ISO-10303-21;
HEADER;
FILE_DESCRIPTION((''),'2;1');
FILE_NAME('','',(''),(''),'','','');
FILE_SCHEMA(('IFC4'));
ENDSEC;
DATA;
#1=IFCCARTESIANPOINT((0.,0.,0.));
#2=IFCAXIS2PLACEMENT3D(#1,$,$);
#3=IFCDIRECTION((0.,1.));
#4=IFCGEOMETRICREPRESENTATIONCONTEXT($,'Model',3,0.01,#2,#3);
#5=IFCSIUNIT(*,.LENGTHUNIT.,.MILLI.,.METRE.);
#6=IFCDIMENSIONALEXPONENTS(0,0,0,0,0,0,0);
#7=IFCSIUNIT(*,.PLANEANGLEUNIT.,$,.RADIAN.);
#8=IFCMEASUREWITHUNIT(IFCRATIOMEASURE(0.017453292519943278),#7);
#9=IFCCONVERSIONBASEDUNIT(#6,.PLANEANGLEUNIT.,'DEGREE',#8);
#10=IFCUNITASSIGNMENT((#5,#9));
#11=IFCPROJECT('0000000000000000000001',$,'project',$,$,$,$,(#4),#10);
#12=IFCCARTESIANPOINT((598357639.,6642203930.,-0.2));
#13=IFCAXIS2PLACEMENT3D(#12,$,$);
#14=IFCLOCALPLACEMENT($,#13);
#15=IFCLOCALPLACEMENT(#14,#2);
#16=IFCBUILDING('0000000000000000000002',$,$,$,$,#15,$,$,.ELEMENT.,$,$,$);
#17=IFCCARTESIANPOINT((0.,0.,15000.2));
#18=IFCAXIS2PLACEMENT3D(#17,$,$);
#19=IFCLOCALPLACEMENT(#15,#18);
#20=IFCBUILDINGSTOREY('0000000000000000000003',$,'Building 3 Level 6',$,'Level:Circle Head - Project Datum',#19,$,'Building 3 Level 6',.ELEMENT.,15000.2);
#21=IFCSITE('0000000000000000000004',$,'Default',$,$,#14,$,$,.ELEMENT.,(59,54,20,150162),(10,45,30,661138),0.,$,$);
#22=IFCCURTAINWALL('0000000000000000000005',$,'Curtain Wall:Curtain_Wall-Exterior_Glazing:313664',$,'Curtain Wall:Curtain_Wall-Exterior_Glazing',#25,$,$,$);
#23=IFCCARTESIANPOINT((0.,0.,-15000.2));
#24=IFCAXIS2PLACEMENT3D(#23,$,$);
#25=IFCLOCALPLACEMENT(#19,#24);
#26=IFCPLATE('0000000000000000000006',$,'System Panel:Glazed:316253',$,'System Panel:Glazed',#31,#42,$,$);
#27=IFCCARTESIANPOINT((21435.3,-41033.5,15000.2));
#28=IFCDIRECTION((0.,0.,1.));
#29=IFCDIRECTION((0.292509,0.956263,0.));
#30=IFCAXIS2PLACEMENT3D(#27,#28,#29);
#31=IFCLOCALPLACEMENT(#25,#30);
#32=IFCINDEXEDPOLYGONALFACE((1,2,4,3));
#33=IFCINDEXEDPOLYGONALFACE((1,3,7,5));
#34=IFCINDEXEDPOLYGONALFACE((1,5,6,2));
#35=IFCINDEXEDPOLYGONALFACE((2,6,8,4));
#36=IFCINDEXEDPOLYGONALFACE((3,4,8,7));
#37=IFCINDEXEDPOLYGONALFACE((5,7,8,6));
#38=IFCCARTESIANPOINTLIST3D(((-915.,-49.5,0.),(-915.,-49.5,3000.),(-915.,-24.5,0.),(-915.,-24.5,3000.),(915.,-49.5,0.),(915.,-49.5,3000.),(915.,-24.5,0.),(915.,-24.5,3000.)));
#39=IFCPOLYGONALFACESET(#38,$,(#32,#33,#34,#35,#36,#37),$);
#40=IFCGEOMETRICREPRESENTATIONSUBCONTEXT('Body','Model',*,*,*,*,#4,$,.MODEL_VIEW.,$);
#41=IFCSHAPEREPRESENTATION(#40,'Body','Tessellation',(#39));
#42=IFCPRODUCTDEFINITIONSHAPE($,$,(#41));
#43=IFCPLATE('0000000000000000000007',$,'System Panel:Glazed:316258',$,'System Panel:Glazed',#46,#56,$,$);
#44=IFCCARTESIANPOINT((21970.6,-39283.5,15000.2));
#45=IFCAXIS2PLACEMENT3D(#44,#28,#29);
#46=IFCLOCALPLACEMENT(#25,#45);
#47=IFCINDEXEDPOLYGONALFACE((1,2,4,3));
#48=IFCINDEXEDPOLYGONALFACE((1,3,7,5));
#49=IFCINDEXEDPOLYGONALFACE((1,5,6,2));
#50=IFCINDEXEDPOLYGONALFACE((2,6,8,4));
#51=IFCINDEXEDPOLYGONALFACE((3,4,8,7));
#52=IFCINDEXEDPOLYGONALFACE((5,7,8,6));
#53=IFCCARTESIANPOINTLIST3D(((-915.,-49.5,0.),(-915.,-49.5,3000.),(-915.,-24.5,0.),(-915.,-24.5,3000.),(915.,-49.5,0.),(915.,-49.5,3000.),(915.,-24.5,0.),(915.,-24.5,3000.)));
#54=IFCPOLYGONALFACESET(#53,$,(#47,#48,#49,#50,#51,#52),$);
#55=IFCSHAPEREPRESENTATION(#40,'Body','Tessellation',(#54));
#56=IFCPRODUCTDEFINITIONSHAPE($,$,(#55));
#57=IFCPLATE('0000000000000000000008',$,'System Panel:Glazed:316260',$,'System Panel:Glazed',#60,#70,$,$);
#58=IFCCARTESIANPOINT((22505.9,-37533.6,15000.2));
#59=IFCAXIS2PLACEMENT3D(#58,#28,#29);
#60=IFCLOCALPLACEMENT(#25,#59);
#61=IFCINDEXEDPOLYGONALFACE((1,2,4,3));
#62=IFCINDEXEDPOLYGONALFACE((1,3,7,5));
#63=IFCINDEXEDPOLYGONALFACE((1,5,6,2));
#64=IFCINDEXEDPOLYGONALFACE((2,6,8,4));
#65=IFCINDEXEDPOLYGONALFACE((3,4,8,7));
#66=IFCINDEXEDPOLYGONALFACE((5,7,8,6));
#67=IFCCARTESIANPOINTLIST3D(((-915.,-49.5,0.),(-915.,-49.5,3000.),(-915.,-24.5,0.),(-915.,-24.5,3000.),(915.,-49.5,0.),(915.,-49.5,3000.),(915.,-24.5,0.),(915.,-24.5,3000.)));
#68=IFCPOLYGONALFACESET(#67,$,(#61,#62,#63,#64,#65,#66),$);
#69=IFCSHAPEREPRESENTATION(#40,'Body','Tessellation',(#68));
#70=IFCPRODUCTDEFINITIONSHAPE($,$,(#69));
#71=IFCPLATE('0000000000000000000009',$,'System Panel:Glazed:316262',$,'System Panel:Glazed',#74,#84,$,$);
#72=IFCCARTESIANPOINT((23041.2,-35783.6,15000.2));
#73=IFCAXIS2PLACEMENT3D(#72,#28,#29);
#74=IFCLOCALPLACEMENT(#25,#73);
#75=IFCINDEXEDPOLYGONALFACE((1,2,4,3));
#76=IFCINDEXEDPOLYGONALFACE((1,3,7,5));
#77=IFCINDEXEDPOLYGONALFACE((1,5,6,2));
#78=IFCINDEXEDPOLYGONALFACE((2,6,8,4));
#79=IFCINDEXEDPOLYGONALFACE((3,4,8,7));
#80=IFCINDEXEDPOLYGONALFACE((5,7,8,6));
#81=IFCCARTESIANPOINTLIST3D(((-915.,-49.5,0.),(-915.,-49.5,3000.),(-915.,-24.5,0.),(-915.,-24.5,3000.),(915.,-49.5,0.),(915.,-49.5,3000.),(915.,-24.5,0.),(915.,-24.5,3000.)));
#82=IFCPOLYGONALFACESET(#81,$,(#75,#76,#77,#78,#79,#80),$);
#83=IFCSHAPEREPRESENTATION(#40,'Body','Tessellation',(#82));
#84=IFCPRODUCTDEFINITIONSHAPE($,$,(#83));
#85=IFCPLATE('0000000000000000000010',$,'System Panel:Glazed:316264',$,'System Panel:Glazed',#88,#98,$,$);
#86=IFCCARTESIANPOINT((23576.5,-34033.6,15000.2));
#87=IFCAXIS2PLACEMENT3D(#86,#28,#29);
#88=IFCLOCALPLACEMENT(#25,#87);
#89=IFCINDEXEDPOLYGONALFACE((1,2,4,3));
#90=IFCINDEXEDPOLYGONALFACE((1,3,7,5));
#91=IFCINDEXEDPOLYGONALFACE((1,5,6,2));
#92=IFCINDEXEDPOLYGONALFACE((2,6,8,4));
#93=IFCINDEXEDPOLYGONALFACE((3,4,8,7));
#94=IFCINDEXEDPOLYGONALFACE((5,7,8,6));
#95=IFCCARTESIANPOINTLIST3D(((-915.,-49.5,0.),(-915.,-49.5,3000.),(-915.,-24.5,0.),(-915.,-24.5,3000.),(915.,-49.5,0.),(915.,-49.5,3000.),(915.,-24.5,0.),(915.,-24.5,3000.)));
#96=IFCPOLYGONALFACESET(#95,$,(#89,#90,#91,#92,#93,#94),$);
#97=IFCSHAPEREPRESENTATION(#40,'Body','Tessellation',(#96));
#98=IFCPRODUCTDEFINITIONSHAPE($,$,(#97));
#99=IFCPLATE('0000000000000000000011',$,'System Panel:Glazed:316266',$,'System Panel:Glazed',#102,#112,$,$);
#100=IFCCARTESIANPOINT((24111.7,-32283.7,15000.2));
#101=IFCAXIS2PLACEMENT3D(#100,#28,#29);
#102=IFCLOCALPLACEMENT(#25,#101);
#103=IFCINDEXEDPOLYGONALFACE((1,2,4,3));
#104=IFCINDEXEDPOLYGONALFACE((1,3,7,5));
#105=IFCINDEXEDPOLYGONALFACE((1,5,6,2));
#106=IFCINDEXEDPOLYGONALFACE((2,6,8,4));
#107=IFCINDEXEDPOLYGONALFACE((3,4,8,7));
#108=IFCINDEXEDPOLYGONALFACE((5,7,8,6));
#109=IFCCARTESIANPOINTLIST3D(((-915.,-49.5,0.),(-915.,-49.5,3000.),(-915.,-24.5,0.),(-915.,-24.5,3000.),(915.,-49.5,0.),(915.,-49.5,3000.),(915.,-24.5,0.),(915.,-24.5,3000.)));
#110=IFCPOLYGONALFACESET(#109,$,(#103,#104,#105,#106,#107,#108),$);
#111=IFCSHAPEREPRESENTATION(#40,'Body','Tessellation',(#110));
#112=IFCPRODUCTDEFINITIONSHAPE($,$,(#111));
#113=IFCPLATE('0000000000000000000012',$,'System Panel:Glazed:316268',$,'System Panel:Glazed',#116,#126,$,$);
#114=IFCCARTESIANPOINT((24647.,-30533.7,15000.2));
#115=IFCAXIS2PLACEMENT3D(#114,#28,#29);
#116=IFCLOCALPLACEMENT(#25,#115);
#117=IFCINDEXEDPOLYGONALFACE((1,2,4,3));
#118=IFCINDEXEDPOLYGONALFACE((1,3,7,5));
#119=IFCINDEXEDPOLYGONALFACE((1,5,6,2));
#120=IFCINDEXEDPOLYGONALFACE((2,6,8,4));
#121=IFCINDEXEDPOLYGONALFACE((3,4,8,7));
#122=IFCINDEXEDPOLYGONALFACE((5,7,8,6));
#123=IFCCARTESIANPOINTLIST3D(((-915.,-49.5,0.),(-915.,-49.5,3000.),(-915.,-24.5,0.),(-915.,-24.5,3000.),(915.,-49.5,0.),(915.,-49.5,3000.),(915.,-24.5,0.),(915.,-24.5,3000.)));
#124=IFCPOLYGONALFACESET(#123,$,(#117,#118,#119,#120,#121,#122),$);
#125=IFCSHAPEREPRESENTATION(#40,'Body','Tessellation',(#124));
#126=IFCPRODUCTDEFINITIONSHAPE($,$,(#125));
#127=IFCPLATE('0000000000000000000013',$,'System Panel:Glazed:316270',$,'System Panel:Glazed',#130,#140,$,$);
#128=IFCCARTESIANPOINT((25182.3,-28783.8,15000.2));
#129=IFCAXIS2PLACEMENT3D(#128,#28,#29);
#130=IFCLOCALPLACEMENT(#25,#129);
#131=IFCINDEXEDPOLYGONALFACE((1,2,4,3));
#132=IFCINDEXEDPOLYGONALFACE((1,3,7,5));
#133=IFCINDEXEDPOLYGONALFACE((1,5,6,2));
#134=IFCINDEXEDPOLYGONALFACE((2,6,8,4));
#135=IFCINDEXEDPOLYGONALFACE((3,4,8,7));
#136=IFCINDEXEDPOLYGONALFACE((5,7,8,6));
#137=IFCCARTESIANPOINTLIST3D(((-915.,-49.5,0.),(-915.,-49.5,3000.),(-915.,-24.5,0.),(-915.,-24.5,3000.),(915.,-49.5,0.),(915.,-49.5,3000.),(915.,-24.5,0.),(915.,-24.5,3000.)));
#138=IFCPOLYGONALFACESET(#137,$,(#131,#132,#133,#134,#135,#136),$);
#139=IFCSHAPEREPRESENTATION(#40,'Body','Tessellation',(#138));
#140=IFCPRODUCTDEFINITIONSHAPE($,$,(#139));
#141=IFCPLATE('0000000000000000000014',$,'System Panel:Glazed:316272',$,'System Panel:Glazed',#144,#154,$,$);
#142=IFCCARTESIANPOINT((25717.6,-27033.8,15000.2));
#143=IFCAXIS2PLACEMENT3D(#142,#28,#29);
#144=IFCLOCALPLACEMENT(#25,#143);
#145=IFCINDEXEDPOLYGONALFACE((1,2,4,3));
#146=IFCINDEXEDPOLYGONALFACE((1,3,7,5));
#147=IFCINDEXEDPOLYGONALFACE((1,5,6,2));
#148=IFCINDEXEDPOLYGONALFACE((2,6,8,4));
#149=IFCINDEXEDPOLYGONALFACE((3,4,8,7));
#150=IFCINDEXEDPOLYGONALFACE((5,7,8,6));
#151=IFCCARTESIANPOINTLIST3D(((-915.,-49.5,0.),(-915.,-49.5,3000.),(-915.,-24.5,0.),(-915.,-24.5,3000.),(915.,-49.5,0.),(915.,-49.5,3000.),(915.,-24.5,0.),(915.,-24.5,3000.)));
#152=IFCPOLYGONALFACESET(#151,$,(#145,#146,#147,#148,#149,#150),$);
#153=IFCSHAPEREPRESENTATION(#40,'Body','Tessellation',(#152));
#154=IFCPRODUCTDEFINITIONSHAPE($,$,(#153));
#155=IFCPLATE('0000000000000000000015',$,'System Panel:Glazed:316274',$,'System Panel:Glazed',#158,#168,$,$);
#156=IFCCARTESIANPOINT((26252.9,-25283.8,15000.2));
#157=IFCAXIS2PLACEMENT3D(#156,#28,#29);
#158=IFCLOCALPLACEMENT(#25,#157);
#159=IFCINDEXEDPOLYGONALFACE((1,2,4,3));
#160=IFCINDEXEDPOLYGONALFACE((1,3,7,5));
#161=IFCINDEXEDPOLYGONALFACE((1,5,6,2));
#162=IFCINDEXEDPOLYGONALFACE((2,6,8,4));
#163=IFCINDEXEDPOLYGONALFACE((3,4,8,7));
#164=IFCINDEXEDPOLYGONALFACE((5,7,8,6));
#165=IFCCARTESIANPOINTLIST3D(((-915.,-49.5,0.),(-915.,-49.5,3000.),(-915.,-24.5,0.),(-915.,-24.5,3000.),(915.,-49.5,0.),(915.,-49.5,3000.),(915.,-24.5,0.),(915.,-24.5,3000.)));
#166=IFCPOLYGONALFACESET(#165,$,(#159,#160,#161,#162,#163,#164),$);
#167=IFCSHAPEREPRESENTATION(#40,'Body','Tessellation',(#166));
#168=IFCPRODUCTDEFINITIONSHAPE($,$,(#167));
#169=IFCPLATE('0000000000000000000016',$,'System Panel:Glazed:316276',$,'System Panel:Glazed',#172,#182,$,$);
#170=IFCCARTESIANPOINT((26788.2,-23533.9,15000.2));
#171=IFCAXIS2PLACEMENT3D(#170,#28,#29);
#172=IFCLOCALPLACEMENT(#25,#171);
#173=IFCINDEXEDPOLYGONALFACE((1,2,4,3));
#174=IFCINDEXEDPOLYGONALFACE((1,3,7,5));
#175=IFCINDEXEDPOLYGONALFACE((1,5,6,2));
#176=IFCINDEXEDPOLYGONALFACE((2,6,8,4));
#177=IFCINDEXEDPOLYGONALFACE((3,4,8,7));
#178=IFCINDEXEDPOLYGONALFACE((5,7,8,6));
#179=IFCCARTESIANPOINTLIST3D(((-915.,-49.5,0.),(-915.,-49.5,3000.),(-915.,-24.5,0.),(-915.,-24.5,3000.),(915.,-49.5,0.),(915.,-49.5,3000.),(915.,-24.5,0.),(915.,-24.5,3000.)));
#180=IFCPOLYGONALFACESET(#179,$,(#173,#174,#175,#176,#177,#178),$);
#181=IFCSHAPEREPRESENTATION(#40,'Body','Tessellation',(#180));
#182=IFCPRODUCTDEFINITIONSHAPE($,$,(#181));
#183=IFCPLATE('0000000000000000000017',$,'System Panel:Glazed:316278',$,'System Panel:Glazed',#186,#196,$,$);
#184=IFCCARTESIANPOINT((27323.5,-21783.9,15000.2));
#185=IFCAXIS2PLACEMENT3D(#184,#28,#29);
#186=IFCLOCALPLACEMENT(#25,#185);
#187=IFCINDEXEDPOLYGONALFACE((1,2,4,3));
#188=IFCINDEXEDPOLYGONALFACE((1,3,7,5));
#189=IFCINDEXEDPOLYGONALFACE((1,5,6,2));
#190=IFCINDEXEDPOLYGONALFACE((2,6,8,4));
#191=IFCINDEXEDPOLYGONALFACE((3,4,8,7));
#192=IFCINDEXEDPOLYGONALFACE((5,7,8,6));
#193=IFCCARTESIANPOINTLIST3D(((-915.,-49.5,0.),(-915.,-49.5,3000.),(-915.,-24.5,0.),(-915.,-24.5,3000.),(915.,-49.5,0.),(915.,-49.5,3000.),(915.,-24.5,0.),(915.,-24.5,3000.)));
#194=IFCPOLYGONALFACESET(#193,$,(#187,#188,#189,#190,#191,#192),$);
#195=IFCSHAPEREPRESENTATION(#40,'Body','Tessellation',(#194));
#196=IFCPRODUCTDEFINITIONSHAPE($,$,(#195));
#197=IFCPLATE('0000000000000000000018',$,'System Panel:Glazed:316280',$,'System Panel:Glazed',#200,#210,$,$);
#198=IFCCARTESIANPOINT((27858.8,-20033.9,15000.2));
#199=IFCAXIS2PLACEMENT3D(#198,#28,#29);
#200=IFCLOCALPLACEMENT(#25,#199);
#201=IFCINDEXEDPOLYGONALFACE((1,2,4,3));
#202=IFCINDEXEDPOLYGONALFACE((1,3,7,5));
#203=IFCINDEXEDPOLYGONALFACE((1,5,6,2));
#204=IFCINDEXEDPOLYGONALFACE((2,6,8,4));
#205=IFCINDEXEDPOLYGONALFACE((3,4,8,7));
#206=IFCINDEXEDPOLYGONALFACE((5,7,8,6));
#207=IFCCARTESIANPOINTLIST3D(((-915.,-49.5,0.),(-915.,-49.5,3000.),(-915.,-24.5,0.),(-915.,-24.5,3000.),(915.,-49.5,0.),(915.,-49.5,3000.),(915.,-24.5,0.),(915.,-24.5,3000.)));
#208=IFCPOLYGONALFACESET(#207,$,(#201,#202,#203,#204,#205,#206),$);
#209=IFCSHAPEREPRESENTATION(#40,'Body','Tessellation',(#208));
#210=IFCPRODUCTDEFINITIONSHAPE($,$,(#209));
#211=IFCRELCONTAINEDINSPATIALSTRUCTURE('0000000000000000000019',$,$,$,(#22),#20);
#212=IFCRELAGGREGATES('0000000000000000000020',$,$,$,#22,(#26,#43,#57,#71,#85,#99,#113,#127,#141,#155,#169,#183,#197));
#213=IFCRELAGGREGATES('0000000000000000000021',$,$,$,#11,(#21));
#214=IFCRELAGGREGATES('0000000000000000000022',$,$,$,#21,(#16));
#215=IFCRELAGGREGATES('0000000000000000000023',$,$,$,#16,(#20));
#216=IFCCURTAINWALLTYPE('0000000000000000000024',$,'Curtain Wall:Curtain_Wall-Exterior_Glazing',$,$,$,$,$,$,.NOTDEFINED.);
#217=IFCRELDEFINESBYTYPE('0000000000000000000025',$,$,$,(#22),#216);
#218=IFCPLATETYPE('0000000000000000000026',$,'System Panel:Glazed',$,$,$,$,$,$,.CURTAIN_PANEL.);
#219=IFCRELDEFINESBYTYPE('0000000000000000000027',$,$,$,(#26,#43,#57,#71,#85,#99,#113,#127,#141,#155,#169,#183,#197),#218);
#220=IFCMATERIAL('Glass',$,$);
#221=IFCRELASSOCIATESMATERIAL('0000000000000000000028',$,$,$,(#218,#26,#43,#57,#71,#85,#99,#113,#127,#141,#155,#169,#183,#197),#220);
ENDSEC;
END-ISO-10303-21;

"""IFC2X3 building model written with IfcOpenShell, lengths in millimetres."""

from ifc_helpers import new_model, entity, si_unit, converted_unit, direction, frame, frame_2d, origin, place, context, subcontext, project, spatial, rectangle, extrude, source, transform, mapped, material, type_object, type_shapes, element, aggregate, save


model = new_model("IFC2X3")

# Units and contexts
model_context = context("Model", 3, precision=0.01, world=origin(), true_north=direction((0.0, 1.0)))
body_context = subcontext(model_context, "Body", "Model", "MODEL_VIEW")
ifc_project = project(units=[si_unit("LENGTHUNIT", "METRE", prefix="MILLI"), converted_unit("PLANEANGLEUNIT", "DEGREE", entity("IfcRatioMeasure", 0.017453292519943278), si_unit("PLANEANGLEUNIT", "RADIAN"), dimensions=[0, 0, 0, 0, 0, 0, 0])], contexts=[model_context])

# Site, building, storey
site_placement = place(None, frame((598357639.0, 6642203930.0, -0.2)))
site = spatial("IfcSite", under=ifc_project, at=site_placement, Name="Default", CompositionType="ELEMENT", RefLatitude=(59, 54, 20, 150162), RefLongitude=(10, 45, 30, 661138), RefElevation=0.0)
building_placement = place(site_placement, origin())
building = spatial("IfcBuilding", under=site, at=building_placement, CompositionType="ELEMENT")
storey_placement = place(building_placement, frame((0.0, 0.0, 15000.2)))
storey = spatial("IfcBuildingStorey", under=building, at=storey_placement, Name="Building 3 Level 6", ObjectType="Level:Circle Head - Project Datum", LongName="Building 3 Level 6", CompositionType="ELEMENT", Elevation=15000.2)

# Curtain wall, plates
curtain_wall_type = type_object("IfcCurtainWallType", Name="Curtain Wall:Curtain_Wall-Exterior_Glazing", PredefinedType="NOTDEFINED")
curtain_wall_1_placement = place(storey_placement, frame((0.0, 0.0, -15000.2)))
curtain_wall_1 = element("IfcCurtainWall", 1, at=curtain_wall_1_placement, inside=storey, type_object=curtain_wall_type, Name="Curtain Wall:Curtain_Wall-Exterior_Glazing:313664", ObjectType="Curtain Wall:Curtain_Wall-Exterior_Glazing")
ifc_material_1 = material(Name="Glass")
plate_type_1 = type_object("IfcPlateType", Name="System Panel:Glazed", PredefinedType="CURTAIN_PANEL", material=ifc_material_1)
shared_shape_1 = source(origin(), body_context, "Body", "SweptSolid", [
    extrude(rectangle(XDim=25.0, YDim=1830.0, at=frame_2d((0.0, 0.0), x_axis=(1.0, 0.0))), frame((0.0, -37.0, 0.0), z_axis=(0.0, 0.0, 1.0), x_axis=(0.0, 1.0, 0.0)), (0.0, 0.0, 1.0), 3000.0),
])
type_shapes(plate_type_1, [shared_shape_1])
plate_1_placement = place(curtain_wall_1_placement, frame((21435.3, -41033.5, 15000.2), z_axis=(0.0, 0.0, 1.0), x_axis=(0.292509, 0.956263, 0.0)))
plate_1 = element("IfcPlate", 2, at=plate_1_placement, type_object=plate_type_1, material=ifc_material_1, Name="System Panel:Glazed:316253", ObjectType="System Panel:Glazed", context=body_context, shape_type="MappedRepresentation", body=[
    mapped(shared_shape_1, transform((0.0, 0.0, 0.0), scale=1.0)),
])
plate_2_placement = place(curtain_wall_1_placement, frame((21970.6, -39283.5, 15000.2), z_axis=(0.0, 0.0, 1.0), x_axis=(0.292509, 0.956263, 0.0)))
plate_2 = element("IfcPlate", 3, at=plate_2_placement, type_object=plate_type_1, material=ifc_material_1, Name="System Panel:Glazed:316258", ObjectType="System Panel:Glazed", context=body_context, shape_type="MappedRepresentation", body=[
    mapped(shared_shape_1, transform((0.0, 0.0, 0.0), scale=1.0)),
])
plate_3_placement = place(curtain_wall_1_placement, frame((22505.9, -37533.6, 15000.2), z_axis=(0.0, 0.0, 1.0), x_axis=(0.292509, 0.956263, 0.0)))
plate_3 = element("IfcPlate", 4, at=plate_3_placement, type_object=plate_type_1, material=ifc_material_1, Name="System Panel:Glazed:316260", ObjectType="System Panel:Glazed", context=body_context, shape_type="MappedRepresentation", body=[
    mapped(shared_shape_1, transform((0.0, 0.0, 0.0), scale=1.0)),
])
plate_4_placement = place(curtain_wall_1_placement, frame((23041.2, -35783.6, 15000.2), z_axis=(0.0, 0.0, 1.0), x_axis=(0.292509, 0.956263, 0.0)))
plate_4 = element("IfcPlate", 5, at=plate_4_placement, type_object=plate_type_1, material=ifc_material_1, Name="System Panel:Glazed:316262", ObjectType="System Panel:Glazed", context=body_context, shape_type="MappedRepresentation", body=[
    mapped(shared_shape_1, transform((0.0, 0.0, 0.0), scale=1.0)),
])
plate_5_placement = place(curtain_wall_1_placement, frame((23576.5, -34033.6, 15000.2), z_axis=(0.0, 0.0, 1.0), x_axis=(0.292509, 0.956263, 0.0)))
plate_5 = element("IfcPlate", 6, at=plate_5_placement, type_object=plate_type_1, material=ifc_material_1, Name="System Panel:Glazed:316264", ObjectType="System Panel:Glazed", context=body_context, shape_type="MappedRepresentation", body=[
    mapped(shared_shape_1, transform((0.0, 0.0, 0.0), scale=1.0)),
])
plate_6_placement = place(curtain_wall_1_placement, frame((24111.7, -32283.7, 15000.2), z_axis=(0.0, 0.0, 1.0), x_axis=(0.292509, 0.956263, 0.0)))
plate_6 = element("IfcPlate", 7, at=plate_6_placement, type_object=plate_type_1, material=ifc_material_1, Name="System Panel:Glazed:316266", ObjectType="System Panel:Glazed", context=body_context, shape_type="MappedRepresentation", body=[
    mapped(shared_shape_1, transform((0.0, 0.0, 0.0), scale=1.0)),
])
plate_7_placement = place(curtain_wall_1_placement, frame((24647.0, -30533.7, 15000.2), z_axis=(0.0, 0.0, 1.0), x_axis=(0.292509, 0.956263, 0.0)))
plate_7 = element("IfcPlate", 8, at=plate_7_placement, type_object=plate_type_1, material=ifc_material_1, Name="System Panel:Glazed:316268", ObjectType="System Panel:Glazed", context=body_context, shape_type="MappedRepresentation", body=[
    mapped(shared_shape_1, transform((0.0, 0.0, 0.0), scale=1.0)),
])
plate_8_placement = place(curtain_wall_1_placement, frame((25182.3, -28783.8, 15000.2), z_axis=(0.0, 0.0, 1.0), x_axis=(0.292509, 0.956263, 0.0)))
plate_8 = element("IfcPlate", 9, at=plate_8_placement, type_object=plate_type_1, material=ifc_material_1, Name="System Panel:Glazed:316270", ObjectType="System Panel:Glazed", context=body_context, shape_type="MappedRepresentation", body=[
    mapped(shared_shape_1, transform((0.0, 0.0, 0.0), scale=1.0)),
])
plate_9_placement = place(curtain_wall_1_placement, frame((25717.6, -27033.8, 15000.2), z_axis=(0.0, 0.0, 1.0), x_axis=(0.292509, 0.956263, 0.0)))
plate_9 = element("IfcPlate", 10, at=plate_9_placement, type_object=plate_type_1, material=ifc_material_1, Name="System Panel:Glazed:316272", ObjectType="System Panel:Glazed", context=body_context, shape_type="MappedRepresentation", body=[
    mapped(shared_shape_1, transform((0.0, 0.0, 0.0), scale=1.0)),
])
plate_10_placement = place(curtain_wall_1_placement, frame((26252.9, -25283.8, 15000.2), z_axis=(0.0, 0.0, 1.0), x_axis=(0.292509, 0.956263, 0.0)))
plate_10 = element("IfcPlate", 11, at=plate_10_placement, type_object=plate_type_1, material=ifc_material_1, Name="System Panel:Glazed:316274", ObjectType="System Panel:Glazed", context=body_context, shape_type="MappedRepresentation", body=[
    mapped(shared_shape_1, transform((0.0, 0.0, 0.0), scale=1.0)),
])
plate_11_placement = place(curtain_wall_1_placement, frame((26788.2, -23533.9, 15000.2), z_axis=(0.0, 0.0, 1.0), x_axis=(0.292509, 0.956263, 0.0)))
plate_11 = element("IfcPlate", 12, at=plate_11_placement, type_object=plate_type_1, material=ifc_material_1, Name="System Panel:Glazed:316276", ObjectType="System Panel:Glazed", context=body_context, shape_type="MappedRepresentation", body=[
    mapped(shared_shape_1, transform((0.0, 0.0, 0.0), scale=1.0)),
])
plate_12_placement = place(curtain_wall_1_placement, frame((27323.5, -21783.9, 15000.2), z_axis=(0.0, 0.0, 1.0), x_axis=(0.292509, 0.956263, 0.0)))
plate_12 = element("IfcPlate", 13, at=plate_12_placement, type_object=plate_type_1, material=ifc_material_1, Name="System Panel:Glazed:316278", ObjectType="System Panel:Glazed", context=body_context, shape_type="MappedRepresentation", body=[
    mapped(shared_shape_1, transform((0.0, 0.0, 0.0), scale=1.0)),
])
plate_13_placement = place(curtain_wall_1_placement, frame((27858.8, -20033.9, 15000.2), z_axis=(0.0, 0.0, 1.0), x_axis=(0.292509, 0.956263, 0.0)))
plate_13 = element("IfcPlate", 14, at=plate_13_placement, type_object=plate_type_1, material=ifc_material_1, Name="System Panel:Glazed:316280", ObjectType="System Panel:Glazed", context=body_context, shape_type="MappedRepresentation", body=[
    mapped(shared_shape_1, transform((0.0, 0.0, 0.0), scale=1.0)),
])

aggregate(curtain_wall_1, [plate_1, plate_2, plate_3, plate_4, plate_5, plate_6, plate_7, plate_8, plate_9, plate_10, plate_11, plate_12, plate_13])

save(model, "model.ifc")
